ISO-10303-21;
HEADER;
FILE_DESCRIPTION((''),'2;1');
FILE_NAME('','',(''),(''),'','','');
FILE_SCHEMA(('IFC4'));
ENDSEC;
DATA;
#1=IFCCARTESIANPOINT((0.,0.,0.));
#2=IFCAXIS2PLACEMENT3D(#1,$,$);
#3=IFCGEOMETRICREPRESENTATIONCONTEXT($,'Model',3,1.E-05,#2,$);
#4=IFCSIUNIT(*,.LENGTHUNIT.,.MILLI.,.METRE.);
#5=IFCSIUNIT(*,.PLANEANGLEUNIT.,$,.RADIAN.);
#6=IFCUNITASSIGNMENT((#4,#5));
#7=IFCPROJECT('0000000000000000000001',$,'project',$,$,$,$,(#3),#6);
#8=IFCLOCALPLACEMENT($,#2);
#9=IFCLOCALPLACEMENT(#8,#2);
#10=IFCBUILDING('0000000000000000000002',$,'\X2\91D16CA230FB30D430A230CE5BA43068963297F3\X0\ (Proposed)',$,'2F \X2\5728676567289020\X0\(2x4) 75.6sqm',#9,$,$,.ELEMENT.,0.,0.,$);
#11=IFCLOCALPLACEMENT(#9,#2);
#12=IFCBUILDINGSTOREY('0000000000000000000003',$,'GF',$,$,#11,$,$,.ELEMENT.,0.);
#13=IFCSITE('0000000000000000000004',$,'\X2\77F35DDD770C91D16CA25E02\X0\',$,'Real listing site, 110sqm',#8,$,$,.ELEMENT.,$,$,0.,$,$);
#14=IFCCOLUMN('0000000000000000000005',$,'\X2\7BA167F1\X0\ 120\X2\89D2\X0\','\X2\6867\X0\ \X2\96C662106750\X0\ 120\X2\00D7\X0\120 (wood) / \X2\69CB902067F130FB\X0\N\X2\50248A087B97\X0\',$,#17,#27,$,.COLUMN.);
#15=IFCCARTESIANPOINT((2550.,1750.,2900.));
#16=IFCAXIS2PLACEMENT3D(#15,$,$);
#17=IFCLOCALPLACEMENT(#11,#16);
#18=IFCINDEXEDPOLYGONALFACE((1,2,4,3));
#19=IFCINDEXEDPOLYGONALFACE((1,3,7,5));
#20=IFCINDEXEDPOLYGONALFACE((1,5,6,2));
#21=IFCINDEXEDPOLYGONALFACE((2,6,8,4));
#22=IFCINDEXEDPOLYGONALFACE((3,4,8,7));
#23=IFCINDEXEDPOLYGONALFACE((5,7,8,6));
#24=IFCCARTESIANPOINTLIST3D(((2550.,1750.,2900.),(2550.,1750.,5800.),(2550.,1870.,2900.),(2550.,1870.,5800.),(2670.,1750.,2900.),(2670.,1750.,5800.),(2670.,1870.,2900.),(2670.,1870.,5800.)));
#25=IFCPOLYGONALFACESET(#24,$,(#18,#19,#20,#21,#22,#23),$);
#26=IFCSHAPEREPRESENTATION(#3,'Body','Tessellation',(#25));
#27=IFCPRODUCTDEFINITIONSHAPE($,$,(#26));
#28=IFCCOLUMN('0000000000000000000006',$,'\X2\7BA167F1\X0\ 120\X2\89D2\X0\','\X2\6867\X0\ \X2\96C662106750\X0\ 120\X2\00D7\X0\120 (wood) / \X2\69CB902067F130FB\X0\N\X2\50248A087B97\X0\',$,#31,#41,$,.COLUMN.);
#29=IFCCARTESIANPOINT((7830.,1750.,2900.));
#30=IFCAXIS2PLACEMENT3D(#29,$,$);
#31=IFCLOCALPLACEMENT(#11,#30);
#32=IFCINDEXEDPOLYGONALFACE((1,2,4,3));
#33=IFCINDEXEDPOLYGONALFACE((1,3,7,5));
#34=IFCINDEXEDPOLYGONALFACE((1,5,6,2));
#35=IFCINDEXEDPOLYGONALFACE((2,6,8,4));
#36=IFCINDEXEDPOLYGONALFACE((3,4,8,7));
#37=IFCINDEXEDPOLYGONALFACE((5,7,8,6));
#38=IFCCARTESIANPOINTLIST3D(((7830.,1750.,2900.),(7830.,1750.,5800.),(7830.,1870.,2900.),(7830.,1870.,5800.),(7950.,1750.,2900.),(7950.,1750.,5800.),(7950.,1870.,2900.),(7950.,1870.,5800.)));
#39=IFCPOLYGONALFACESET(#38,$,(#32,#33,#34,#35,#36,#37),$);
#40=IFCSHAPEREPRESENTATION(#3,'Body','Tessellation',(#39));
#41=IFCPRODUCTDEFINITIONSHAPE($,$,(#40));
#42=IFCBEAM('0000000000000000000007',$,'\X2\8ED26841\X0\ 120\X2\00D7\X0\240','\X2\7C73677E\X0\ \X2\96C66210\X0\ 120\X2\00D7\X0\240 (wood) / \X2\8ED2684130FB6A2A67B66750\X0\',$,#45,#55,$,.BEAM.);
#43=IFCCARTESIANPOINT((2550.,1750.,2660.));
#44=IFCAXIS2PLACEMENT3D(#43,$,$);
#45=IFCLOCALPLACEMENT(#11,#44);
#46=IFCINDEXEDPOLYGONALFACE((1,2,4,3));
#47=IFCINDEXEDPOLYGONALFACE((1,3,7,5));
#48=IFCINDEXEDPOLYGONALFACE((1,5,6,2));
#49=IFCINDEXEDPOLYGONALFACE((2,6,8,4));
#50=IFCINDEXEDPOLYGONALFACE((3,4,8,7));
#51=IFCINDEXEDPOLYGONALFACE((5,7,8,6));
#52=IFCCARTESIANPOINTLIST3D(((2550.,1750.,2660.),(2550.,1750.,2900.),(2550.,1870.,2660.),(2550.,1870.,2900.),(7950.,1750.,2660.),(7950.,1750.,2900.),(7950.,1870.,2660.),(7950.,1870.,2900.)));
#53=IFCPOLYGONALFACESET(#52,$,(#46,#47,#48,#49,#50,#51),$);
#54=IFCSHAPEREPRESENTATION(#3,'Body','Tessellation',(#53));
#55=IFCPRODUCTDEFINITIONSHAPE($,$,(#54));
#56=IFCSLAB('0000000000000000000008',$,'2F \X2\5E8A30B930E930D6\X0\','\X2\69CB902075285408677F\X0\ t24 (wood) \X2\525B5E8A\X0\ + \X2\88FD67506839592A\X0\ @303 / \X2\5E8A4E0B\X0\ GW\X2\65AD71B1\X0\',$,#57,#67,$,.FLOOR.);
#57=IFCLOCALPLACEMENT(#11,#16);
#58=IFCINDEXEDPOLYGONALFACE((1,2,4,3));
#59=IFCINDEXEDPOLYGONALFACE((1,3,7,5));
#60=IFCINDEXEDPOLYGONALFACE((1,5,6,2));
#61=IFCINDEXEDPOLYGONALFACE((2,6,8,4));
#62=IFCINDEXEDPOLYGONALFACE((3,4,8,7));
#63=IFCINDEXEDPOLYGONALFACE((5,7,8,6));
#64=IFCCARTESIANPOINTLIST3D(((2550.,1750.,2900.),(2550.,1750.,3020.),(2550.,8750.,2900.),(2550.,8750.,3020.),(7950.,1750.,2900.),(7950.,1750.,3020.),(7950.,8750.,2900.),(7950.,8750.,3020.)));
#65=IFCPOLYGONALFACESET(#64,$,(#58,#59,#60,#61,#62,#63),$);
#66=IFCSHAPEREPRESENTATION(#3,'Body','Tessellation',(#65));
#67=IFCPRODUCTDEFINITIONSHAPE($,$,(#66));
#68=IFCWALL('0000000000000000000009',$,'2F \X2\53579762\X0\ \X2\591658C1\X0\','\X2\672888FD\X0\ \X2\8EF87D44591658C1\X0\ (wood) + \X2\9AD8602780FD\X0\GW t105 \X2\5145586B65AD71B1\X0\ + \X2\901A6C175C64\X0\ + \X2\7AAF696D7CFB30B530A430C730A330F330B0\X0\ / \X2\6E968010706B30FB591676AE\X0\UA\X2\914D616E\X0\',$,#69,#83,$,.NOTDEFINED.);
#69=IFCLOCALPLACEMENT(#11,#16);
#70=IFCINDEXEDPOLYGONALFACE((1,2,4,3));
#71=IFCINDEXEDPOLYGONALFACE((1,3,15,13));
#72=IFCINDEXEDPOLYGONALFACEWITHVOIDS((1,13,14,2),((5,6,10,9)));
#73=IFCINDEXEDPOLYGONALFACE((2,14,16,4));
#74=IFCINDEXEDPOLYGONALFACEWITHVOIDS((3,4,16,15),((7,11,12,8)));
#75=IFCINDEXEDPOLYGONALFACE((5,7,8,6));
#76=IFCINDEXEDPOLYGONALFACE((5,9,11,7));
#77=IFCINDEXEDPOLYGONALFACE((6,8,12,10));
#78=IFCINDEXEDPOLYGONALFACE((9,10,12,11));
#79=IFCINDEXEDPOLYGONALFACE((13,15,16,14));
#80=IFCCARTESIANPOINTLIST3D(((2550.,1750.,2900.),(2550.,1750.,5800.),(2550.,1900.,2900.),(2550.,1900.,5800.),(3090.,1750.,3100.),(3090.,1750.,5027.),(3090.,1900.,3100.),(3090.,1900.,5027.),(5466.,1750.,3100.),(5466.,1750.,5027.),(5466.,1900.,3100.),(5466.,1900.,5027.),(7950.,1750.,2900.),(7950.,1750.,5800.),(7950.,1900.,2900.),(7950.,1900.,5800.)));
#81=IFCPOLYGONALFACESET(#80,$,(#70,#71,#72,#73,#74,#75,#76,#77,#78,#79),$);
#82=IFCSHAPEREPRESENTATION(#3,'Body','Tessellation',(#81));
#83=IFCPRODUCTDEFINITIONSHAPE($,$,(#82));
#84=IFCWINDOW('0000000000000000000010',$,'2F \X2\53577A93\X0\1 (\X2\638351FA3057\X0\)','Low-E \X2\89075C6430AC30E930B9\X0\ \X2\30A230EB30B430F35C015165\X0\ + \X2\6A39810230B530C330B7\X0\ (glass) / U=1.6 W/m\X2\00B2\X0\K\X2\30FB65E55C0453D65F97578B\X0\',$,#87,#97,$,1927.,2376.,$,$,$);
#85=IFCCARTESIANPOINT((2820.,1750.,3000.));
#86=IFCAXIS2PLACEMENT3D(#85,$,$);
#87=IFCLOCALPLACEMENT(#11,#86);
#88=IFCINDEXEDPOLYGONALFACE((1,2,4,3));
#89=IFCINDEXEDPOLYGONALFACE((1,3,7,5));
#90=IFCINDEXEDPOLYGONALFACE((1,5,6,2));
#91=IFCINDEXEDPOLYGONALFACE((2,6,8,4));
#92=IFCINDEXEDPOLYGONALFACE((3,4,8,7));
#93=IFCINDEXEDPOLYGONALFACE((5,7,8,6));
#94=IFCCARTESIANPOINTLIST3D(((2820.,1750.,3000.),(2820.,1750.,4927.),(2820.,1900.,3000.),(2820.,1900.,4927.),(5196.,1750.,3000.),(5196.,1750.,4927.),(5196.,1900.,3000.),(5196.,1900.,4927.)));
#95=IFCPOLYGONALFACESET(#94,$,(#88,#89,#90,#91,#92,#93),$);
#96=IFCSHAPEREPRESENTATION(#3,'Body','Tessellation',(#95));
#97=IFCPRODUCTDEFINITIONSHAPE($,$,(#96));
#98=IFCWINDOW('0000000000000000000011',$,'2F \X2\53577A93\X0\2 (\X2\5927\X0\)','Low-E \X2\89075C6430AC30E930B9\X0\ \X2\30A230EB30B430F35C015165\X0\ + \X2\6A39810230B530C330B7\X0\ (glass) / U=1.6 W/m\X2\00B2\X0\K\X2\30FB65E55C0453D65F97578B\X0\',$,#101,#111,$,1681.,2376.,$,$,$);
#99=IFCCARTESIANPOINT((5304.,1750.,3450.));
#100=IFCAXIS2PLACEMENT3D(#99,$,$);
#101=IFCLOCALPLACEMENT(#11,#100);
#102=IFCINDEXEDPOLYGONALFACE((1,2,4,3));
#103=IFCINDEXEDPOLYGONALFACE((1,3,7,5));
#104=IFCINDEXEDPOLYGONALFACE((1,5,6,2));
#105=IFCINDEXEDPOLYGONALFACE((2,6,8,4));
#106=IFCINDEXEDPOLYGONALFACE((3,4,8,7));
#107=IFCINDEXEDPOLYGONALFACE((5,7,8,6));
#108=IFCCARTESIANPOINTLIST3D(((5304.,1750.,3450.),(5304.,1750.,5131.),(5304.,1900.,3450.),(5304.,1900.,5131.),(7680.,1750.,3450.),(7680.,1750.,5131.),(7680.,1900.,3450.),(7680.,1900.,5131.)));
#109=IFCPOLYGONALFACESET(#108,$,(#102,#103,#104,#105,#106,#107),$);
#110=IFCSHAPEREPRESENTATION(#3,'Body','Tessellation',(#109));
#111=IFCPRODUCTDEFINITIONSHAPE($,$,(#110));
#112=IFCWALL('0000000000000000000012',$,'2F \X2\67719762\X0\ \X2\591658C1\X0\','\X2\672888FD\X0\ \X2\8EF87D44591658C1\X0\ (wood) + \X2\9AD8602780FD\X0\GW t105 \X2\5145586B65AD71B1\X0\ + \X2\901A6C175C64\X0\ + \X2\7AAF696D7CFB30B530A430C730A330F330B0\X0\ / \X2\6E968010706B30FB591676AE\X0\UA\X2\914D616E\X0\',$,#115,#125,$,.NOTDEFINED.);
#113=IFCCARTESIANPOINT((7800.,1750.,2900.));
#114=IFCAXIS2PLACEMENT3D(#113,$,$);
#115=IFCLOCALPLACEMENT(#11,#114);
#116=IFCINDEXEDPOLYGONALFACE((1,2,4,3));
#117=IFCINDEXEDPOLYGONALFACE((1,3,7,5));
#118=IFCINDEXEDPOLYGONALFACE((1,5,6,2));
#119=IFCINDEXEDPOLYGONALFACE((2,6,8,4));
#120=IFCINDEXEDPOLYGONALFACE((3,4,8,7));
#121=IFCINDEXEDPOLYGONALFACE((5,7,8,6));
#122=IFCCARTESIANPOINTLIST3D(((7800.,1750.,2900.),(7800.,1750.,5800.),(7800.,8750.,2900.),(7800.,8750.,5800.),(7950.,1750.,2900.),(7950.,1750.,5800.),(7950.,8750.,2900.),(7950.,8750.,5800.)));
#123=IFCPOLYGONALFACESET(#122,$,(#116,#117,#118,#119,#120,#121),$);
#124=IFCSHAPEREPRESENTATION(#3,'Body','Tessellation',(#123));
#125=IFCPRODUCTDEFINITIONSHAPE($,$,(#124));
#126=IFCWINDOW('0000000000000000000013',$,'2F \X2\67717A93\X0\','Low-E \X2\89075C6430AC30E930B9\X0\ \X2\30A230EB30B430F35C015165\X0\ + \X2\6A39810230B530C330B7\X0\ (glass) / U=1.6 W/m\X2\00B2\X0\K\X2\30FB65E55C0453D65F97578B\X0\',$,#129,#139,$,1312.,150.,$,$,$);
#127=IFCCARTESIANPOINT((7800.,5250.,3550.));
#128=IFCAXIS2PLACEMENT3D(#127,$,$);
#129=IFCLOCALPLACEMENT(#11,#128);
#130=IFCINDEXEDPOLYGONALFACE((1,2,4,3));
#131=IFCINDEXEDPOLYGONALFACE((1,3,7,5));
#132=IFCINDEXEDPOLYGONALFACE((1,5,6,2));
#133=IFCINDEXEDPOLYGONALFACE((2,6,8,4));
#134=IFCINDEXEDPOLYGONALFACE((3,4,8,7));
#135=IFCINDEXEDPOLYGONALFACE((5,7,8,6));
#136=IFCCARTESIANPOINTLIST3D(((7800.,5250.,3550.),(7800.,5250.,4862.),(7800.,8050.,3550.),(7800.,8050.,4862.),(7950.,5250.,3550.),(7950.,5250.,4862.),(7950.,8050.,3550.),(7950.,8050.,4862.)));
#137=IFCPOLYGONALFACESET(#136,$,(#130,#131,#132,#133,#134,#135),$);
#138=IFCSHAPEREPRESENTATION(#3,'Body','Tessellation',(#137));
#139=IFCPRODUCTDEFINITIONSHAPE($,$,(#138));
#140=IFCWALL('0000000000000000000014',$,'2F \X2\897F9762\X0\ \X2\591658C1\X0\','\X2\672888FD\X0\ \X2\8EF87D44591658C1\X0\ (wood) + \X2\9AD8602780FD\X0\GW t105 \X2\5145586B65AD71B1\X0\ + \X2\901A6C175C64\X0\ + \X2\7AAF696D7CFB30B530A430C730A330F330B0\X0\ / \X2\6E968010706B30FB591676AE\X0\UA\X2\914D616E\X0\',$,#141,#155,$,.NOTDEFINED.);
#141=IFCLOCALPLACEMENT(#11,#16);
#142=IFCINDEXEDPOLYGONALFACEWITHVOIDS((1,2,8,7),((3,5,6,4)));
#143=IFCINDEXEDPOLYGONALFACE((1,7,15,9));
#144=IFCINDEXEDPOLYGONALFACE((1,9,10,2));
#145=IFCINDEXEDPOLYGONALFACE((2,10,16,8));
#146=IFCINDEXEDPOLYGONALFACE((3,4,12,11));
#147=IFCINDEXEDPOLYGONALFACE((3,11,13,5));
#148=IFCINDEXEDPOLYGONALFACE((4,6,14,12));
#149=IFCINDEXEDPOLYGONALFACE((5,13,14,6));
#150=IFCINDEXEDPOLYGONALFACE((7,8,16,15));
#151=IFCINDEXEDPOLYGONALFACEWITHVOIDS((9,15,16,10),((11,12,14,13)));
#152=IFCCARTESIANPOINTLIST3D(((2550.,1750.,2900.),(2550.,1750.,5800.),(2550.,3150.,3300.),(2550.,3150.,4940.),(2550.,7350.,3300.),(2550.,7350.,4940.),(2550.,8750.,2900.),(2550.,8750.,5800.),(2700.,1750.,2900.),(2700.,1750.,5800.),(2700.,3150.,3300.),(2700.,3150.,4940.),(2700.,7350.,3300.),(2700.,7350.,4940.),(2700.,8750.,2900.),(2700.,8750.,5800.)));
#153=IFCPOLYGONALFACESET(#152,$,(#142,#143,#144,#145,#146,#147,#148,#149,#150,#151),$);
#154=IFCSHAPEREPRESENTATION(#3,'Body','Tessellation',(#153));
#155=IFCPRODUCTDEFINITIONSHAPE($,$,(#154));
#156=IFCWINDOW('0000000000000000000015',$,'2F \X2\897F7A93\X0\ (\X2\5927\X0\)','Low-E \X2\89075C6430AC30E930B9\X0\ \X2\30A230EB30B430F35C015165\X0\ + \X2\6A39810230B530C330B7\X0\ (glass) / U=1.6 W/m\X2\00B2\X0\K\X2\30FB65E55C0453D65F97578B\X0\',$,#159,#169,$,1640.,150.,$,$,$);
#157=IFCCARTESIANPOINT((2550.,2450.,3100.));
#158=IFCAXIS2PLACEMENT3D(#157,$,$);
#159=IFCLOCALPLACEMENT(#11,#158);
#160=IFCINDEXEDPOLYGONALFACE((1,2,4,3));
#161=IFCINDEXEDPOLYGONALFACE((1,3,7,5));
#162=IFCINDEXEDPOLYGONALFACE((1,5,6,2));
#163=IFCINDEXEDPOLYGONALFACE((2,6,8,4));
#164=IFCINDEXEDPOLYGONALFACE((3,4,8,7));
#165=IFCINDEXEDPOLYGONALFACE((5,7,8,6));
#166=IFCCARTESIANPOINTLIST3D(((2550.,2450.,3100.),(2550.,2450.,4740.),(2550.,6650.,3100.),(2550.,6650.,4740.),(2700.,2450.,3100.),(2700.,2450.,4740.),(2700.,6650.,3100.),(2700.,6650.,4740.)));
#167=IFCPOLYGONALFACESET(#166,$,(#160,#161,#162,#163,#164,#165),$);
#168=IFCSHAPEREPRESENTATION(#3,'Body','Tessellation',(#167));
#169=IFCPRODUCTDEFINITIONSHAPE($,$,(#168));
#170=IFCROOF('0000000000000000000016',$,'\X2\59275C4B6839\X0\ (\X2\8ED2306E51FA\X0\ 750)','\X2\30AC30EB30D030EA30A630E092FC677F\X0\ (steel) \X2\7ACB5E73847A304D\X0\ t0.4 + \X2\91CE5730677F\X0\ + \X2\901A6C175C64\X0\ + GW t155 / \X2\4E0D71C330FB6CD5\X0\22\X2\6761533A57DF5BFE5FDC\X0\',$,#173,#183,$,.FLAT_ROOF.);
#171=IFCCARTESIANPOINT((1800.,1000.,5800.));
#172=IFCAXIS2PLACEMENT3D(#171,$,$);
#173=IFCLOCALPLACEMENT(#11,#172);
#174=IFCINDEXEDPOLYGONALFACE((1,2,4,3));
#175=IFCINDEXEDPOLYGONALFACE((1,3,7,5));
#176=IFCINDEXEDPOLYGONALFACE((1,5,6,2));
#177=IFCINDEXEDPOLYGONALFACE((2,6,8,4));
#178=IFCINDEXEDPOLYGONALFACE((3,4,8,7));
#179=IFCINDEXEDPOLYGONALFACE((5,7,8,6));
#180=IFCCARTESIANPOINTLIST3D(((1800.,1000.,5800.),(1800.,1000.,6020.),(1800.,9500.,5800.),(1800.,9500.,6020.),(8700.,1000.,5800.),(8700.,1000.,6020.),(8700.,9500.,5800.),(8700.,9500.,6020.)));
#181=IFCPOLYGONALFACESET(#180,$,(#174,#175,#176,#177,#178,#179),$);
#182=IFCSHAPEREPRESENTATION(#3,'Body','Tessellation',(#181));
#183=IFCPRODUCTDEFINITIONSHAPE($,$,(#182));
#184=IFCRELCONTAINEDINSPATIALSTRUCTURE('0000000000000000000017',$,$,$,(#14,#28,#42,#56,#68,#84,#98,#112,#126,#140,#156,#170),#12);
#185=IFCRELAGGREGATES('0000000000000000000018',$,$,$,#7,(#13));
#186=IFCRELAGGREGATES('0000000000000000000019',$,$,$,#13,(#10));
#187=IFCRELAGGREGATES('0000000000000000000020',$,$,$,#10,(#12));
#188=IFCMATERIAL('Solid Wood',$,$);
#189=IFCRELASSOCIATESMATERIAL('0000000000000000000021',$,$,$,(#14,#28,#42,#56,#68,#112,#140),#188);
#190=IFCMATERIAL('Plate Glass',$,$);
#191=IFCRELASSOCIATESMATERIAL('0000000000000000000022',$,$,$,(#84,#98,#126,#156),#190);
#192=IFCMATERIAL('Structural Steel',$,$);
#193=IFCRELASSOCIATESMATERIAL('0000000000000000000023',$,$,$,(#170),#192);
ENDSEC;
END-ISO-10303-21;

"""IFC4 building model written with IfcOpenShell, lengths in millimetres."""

from ifc_helpers import new_model, si_unit, frame, frame_2d, origin, place, context, project, spatial, rectangle, extrude, material, element, fill, save


model = new_model("IFC4")

# Units and contexts
model_context = context("Model", 3, precision=1e-05, world=origin())
ifc_project = project(units=[si_unit("LENGTHUNIT", "METRE", prefix="MILLI"), si_unit("PLANEANGLEUNIT", "RADIAN")], contexts=[model_context])

# Site, building, storey
site_placement = place(None, origin())
site = spatial("IfcSite", under=ifc_project, at=site_placement, Name="石川県金沢市", ObjectType="Real listing site, 110sqm", CompositionType="ELEMENT", RefElevation=0.0)
building_placement = place(site_placement, origin())
building = spatial("IfcBuilding", under=site, at=building_placement, Name="金沢・ピアノ室と防音 (Proposed)", ObjectType="2F 在来木造(2x4) 75.6sqm", CompositionType="ELEMENT", ElevationOfRefHeight=0.0, ElevationOfTerrain=0.0)
storey_placement = place(building_placement, origin())
storey = spatial("IfcBuildingStorey", under=building, at=storey_placement, Name="GF", CompositionType="ELEMENT", Elevation=0.0)

# Columns
ifc_material_1 = material(Name="Solid Wood")
column_1_placement = place(storey_placement, frame((2550.0, 1750.0, 2900.0)))
element("IfcColumn", 1, at=column_1_placement, inside=storey, material=ifc_material_1, Name="管柱 120角", Description="桧 集成材 120×120 (wood) / 構造柱・N値計算", PredefinedType="COLUMN", context=model_context, shape_type="SweptSolid", body=[
    extrude(rectangle(XDim=120.0, YDim=120.0, at=frame_2d((60.0, 60.0))), frame((2550.0, 1750.0, 2900.0)), (0.0, 0.0, 1.0), 2900.0),
])
column_2_placement = place(storey_placement, frame((7830.0, 1750.0, 2900.0)))
element("IfcColumn", 2, at=column_2_placement, inside=storey, material=ifc_material_1, Name="管柱 120角", Description="桧 集成材 120×120 (wood) / 構造柱・N値計算", PredefinedType="COLUMN", context=model_context, shape_type="SweptSolid", body=[
    extrude(rectangle(XDim=120.0, YDim=120.0, at=frame_2d((60.0, 60.0))), frame((7830.0, 1750.0, 2900.0)), (0.0, 0.0, 1.0), 2900.0),
])

# Beam
beam_1_placement = place(storey_placement, frame((2550.0, 1750.0, 2660.0)))
element("IfcBeam", 3, at=beam_1_placement, inside=storey, material=ifc_material_1, Name="軒桁 120×240", Description="米松 集成 120×240 (wood) / 軒桁・横架材", PredefinedType="BEAM", context=model_context, shape_type="SweptSolid", body=[
    extrude(rectangle(XDim=5400.0, YDim=120.0, at=frame_2d((2700.0, 60.0))), frame((2550.0, 1750.0, 2660.0)), (0.0, 0.0, 1.0), 240.0),
])

# Slab
slab_placement = place(storey_placement, frame((2550.0, 1750.0, 2900.0)))
element("IfcSlab", 4, at=slab_placement, inside=storey, material=ifc_material_1, Name="2F 床スラブ", Description="構造用合板 t24 (wood) 剛床 + 製材根太 @303 / 床下 GW断熱", PredefinedType="FLOOR", context=model_context, shape_type="SweptSolid", body=[
    extrude(rectangle(XDim=5400.0, YDim=7000.0, at=frame_2d((2700.0, 3500.0))), frame((2550.0, 1750.0, 2900.0)), (0.0, 0.0, 1.0), 120.0),
])

# Wall, openings, windows
wall_1_placement = place(storey_placement, frame((2550.0, 1750.0, 2900.0)))
wall_1 = element("IfcWall", 5, at=wall_1_placement, inside=storey, material=ifc_material_1, Name="2F 南面 外壁", Description="木製 軸組外壁 (wood) + 高性能GW t105 充填断熱 + 通気層 + 窯業系サイディング / 準耐火・外皮UA配慮", PredefinedType="NOTDEFINED", context=model_context, shape_type="SweptSolid", body=[
    extrude(rectangle(XDim=5400.0, YDim=150.0, at=frame_2d((2700.0, 75.0))), frame((2550.0, 1750.0, 2900.0)), (0.0, 0.0, 1.0), 2900.0),
])
opening_1_placement = place(storey_placement, frame((2820.0, 1750.0, 3000.0)))
opening_1 = element("IfcOpeningElement", 6, at=opening_1_placement, cuts=wall_1, PredefinedType="NOTDEFINED", context=model_context, shape_type="SweptSolid", body=[
    extrude(rectangle(XDim=2376.0, YDim=150.0, at=frame_2d((1188.0, 75.0))), frame((2820.0, 1750.0, 3000.0)), (0.0, 0.0, 1.0), 1927.0),
])
opening_2_placement = place(storey_placement, frame((5304.0, 1750.0, 3450.0)))
opening_2 = element("IfcOpeningElement", 7, at=opening_2_placement, cuts=wall_1, PredefinedType="NOTDEFINED", context=model_context, shape_type="SweptSolid", body=[
    extrude(rectangle(XDim=2376.0, YDim=150.0, at=frame_2d((1188.0, 75.0))), frame((5304.0, 1750.0, 3450.0)), (0.0, 0.0, 1.0), 1681.0),
])
ifc_material_2 = material(Name="Plate Glass")
window_1_placement = place(storey_placement, frame((2820.0, 1750.0, 3000.0)))
window_1 = element("IfcWindow", 8, at=window_1_placement, inside=storey, material=ifc_material_2, Name="2F 南窓1 (掃出し)", Description="Low-E 複層ガラス アルゴン封入 + 樹脂サッシ (glass) / U=1.6 W/m²K・日射取得型", OverallHeight=1927.0, OverallWidth=2376.0, context=model_context, shape_type="SweptSolid", body=[
    extrude(rectangle(XDim=2376.0, YDim=150.0, at=frame_2d((1188.0, 75.0))), frame((2820.0, 1750.0, 3000.0)), (0.0, 0.0, 1.0), 1927.0),
])
fill(opening_1, window_1)
window_2_placement = place(storey_placement, frame((5304.0, 1750.0, 3450.0)))
window_2 = element("IfcWindow", 9, at=window_2_placement, inside=storey, material=ifc_material_2, Name="2F 南窓2 (大)", Description="Low-E 複層ガラス アルゴン封入 + 樹脂サッシ (glass) / U=1.6 W/m²K・日射取得型", OverallHeight=1681.0, OverallWidth=2376.0, context=model_context, shape_type="SweptSolid", body=[
    extrude(rectangle(XDim=2376.0, YDim=150.0, at=frame_2d((1188.0, 75.0))), frame((5304.0, 1750.0, 3450.0)), (0.0, 0.0, 1.0), 1681.0),
])
fill(opening_2, window_2)

# Walls, openings, windows
wall_2_placement = place(storey_placement, frame((7800.0, 1750.0, 2900.0)))
wall_2 = element("IfcWall", 10, at=wall_2_placement, inside=storey, material=ifc_material_1, Name="2F 東面 外壁", Description="木製 軸組外壁 (wood) + 高性能GW t105 充填断熱 + 通気層 + 窯業系サイディング / 準耐火・外皮UA配慮", PredefinedType="NOTDEFINED", context=model_context, shape_type="SweptSolid", body=[
    extrude(rectangle(XDim=150.0, YDim=7000.0, at=frame_2d((75.0, 3500.0))), frame((7800.0, 1750.0, 2900.0)), (0.0, 0.0, 1.0), 2900.0),
])
opening_3_placement = place(storey_placement, frame((7800.0, 5250.0, 3550.0)))
opening_3 = element("IfcOpeningElement", 11, at=opening_3_placement, cuts=wall_2, PredefinedType="NOTDEFINED", context=model_context, shape_type="SweptSolid", body=[
    extrude(rectangle(XDim=150.0, YDim=2800.0, at=frame_2d((75.0, 1400.0))), frame((7800.0, 5250.0, 3550.0)), (0.0, 0.0, 1.0), 1312.0),
])
window_3_placement = place(storey_placement, frame((7800.0, 5250.0, 3550.0)))
window_3 = element("IfcWindow", 12, at=window_3_placement, inside=storey, material=ifc_material_2, Name="2F 東窓", Description="Low-E 複層ガラス アルゴン封入 + 樹脂サッシ (glass) / U=1.6 W/m²K・日射取得型", OverallHeight=1312.0, OverallWidth=150.0, context=model_context, shape_type="SweptSolid", body=[
    extrude(rectangle(XDim=150.0, YDim=2800.0, at=frame_2d((75.0, 1400.0))), frame((7800.0, 5250.0, 3550.0)), (0.0, 0.0, 1.0), 1312.0),
])
fill(opening_3, window_3)
wall_3_placement = place(storey_placement, frame((2550.0, 1750.0, 2900.0)))
wall_3 = element("IfcWall", 13, at=wall_3_placement, inside=storey, material=ifc_material_1, Name="2F 西面 外壁", Description="木製 軸組外壁 (wood) + 高性能GW t105 充填断熱 + 通気層 + 窯業系サイディング / 準耐火・外皮UA配慮", PredefinedType="NOTDEFINED", context=model_context, shape_type="SweptSolid", body=[
    extrude(rectangle(XDim=150.0, YDim=7000.0, at=frame_2d((75.0, 3500.0))), frame((2550.0, 1750.0, 2900.0)), (0.0, 0.0, 1.0), 2900.0),
])
opening_4_placement = place(storey_placement, frame((2550.0, 2450.0, 3100.0)))
opening_4 = element("IfcOpeningElement", 14, at=opening_4_placement, cuts=wall_3, PredefinedType="NOTDEFINED", context=model_context, shape_type="SweptSolid", body=[
    extrude(rectangle(XDim=150.0, YDim=4200.0, at=frame_2d((75.0, 2100.0))), frame((2550.0, 2450.0, 3100.0)), (0.0, 0.0, 1.0), 1640.0),
])
window_4_placement = place(storey_placement, frame((2550.0, 2450.0, 3100.0)))
window_4 = element("IfcWindow", 15, at=window_4_placement, inside=storey, material=ifc_material_2, Name="2F 西窓 (大)", Description="Low-E 複層ガラス アルゴン封入 + 樹脂サッシ (glass) / U=1.6 W/m²K・日射取得型", OverallHeight=1640.0, OverallWidth=150.0, context=model_context, shape_type="SweptSolid", body=[
    extrude(rectangle(XDim=150.0, YDim=4200.0, at=frame_2d((75.0, 2100.0))), frame((2550.0, 2450.0, 3100.0)), (0.0, 0.0, 1.0), 1640.0),
])
fill(opening_4, window_4)

# Roof
ifc_material_3 = material(Name="Structural Steel")
roof_placement = place(storey_placement, frame((1800.0, 1000.0, 5800.0)))
element("IfcRoof", 16, at=roof_placement, inside=storey, material=ifc_material_3, Name="大屋根 (軒の出 750)", Description="ガルバリウム鋼板 (steel) 立平葺き t0.4 + 野地板 + 通気層 + GW t155 / 不燃・法22条区域対応", PredefinedType="FLAT_ROOF", context=model_context, shape_type="SweptSolid", body=[
    extrude(rectangle(XDim=6900.0, YDim=8500.0, at=frame_2d((3450.0, 4250.0))), frame((1800.0, 1000.0, 5800.0)), (0.0, 0.0, 1.0), 220.0),
])

save(model, "model.ifc")
